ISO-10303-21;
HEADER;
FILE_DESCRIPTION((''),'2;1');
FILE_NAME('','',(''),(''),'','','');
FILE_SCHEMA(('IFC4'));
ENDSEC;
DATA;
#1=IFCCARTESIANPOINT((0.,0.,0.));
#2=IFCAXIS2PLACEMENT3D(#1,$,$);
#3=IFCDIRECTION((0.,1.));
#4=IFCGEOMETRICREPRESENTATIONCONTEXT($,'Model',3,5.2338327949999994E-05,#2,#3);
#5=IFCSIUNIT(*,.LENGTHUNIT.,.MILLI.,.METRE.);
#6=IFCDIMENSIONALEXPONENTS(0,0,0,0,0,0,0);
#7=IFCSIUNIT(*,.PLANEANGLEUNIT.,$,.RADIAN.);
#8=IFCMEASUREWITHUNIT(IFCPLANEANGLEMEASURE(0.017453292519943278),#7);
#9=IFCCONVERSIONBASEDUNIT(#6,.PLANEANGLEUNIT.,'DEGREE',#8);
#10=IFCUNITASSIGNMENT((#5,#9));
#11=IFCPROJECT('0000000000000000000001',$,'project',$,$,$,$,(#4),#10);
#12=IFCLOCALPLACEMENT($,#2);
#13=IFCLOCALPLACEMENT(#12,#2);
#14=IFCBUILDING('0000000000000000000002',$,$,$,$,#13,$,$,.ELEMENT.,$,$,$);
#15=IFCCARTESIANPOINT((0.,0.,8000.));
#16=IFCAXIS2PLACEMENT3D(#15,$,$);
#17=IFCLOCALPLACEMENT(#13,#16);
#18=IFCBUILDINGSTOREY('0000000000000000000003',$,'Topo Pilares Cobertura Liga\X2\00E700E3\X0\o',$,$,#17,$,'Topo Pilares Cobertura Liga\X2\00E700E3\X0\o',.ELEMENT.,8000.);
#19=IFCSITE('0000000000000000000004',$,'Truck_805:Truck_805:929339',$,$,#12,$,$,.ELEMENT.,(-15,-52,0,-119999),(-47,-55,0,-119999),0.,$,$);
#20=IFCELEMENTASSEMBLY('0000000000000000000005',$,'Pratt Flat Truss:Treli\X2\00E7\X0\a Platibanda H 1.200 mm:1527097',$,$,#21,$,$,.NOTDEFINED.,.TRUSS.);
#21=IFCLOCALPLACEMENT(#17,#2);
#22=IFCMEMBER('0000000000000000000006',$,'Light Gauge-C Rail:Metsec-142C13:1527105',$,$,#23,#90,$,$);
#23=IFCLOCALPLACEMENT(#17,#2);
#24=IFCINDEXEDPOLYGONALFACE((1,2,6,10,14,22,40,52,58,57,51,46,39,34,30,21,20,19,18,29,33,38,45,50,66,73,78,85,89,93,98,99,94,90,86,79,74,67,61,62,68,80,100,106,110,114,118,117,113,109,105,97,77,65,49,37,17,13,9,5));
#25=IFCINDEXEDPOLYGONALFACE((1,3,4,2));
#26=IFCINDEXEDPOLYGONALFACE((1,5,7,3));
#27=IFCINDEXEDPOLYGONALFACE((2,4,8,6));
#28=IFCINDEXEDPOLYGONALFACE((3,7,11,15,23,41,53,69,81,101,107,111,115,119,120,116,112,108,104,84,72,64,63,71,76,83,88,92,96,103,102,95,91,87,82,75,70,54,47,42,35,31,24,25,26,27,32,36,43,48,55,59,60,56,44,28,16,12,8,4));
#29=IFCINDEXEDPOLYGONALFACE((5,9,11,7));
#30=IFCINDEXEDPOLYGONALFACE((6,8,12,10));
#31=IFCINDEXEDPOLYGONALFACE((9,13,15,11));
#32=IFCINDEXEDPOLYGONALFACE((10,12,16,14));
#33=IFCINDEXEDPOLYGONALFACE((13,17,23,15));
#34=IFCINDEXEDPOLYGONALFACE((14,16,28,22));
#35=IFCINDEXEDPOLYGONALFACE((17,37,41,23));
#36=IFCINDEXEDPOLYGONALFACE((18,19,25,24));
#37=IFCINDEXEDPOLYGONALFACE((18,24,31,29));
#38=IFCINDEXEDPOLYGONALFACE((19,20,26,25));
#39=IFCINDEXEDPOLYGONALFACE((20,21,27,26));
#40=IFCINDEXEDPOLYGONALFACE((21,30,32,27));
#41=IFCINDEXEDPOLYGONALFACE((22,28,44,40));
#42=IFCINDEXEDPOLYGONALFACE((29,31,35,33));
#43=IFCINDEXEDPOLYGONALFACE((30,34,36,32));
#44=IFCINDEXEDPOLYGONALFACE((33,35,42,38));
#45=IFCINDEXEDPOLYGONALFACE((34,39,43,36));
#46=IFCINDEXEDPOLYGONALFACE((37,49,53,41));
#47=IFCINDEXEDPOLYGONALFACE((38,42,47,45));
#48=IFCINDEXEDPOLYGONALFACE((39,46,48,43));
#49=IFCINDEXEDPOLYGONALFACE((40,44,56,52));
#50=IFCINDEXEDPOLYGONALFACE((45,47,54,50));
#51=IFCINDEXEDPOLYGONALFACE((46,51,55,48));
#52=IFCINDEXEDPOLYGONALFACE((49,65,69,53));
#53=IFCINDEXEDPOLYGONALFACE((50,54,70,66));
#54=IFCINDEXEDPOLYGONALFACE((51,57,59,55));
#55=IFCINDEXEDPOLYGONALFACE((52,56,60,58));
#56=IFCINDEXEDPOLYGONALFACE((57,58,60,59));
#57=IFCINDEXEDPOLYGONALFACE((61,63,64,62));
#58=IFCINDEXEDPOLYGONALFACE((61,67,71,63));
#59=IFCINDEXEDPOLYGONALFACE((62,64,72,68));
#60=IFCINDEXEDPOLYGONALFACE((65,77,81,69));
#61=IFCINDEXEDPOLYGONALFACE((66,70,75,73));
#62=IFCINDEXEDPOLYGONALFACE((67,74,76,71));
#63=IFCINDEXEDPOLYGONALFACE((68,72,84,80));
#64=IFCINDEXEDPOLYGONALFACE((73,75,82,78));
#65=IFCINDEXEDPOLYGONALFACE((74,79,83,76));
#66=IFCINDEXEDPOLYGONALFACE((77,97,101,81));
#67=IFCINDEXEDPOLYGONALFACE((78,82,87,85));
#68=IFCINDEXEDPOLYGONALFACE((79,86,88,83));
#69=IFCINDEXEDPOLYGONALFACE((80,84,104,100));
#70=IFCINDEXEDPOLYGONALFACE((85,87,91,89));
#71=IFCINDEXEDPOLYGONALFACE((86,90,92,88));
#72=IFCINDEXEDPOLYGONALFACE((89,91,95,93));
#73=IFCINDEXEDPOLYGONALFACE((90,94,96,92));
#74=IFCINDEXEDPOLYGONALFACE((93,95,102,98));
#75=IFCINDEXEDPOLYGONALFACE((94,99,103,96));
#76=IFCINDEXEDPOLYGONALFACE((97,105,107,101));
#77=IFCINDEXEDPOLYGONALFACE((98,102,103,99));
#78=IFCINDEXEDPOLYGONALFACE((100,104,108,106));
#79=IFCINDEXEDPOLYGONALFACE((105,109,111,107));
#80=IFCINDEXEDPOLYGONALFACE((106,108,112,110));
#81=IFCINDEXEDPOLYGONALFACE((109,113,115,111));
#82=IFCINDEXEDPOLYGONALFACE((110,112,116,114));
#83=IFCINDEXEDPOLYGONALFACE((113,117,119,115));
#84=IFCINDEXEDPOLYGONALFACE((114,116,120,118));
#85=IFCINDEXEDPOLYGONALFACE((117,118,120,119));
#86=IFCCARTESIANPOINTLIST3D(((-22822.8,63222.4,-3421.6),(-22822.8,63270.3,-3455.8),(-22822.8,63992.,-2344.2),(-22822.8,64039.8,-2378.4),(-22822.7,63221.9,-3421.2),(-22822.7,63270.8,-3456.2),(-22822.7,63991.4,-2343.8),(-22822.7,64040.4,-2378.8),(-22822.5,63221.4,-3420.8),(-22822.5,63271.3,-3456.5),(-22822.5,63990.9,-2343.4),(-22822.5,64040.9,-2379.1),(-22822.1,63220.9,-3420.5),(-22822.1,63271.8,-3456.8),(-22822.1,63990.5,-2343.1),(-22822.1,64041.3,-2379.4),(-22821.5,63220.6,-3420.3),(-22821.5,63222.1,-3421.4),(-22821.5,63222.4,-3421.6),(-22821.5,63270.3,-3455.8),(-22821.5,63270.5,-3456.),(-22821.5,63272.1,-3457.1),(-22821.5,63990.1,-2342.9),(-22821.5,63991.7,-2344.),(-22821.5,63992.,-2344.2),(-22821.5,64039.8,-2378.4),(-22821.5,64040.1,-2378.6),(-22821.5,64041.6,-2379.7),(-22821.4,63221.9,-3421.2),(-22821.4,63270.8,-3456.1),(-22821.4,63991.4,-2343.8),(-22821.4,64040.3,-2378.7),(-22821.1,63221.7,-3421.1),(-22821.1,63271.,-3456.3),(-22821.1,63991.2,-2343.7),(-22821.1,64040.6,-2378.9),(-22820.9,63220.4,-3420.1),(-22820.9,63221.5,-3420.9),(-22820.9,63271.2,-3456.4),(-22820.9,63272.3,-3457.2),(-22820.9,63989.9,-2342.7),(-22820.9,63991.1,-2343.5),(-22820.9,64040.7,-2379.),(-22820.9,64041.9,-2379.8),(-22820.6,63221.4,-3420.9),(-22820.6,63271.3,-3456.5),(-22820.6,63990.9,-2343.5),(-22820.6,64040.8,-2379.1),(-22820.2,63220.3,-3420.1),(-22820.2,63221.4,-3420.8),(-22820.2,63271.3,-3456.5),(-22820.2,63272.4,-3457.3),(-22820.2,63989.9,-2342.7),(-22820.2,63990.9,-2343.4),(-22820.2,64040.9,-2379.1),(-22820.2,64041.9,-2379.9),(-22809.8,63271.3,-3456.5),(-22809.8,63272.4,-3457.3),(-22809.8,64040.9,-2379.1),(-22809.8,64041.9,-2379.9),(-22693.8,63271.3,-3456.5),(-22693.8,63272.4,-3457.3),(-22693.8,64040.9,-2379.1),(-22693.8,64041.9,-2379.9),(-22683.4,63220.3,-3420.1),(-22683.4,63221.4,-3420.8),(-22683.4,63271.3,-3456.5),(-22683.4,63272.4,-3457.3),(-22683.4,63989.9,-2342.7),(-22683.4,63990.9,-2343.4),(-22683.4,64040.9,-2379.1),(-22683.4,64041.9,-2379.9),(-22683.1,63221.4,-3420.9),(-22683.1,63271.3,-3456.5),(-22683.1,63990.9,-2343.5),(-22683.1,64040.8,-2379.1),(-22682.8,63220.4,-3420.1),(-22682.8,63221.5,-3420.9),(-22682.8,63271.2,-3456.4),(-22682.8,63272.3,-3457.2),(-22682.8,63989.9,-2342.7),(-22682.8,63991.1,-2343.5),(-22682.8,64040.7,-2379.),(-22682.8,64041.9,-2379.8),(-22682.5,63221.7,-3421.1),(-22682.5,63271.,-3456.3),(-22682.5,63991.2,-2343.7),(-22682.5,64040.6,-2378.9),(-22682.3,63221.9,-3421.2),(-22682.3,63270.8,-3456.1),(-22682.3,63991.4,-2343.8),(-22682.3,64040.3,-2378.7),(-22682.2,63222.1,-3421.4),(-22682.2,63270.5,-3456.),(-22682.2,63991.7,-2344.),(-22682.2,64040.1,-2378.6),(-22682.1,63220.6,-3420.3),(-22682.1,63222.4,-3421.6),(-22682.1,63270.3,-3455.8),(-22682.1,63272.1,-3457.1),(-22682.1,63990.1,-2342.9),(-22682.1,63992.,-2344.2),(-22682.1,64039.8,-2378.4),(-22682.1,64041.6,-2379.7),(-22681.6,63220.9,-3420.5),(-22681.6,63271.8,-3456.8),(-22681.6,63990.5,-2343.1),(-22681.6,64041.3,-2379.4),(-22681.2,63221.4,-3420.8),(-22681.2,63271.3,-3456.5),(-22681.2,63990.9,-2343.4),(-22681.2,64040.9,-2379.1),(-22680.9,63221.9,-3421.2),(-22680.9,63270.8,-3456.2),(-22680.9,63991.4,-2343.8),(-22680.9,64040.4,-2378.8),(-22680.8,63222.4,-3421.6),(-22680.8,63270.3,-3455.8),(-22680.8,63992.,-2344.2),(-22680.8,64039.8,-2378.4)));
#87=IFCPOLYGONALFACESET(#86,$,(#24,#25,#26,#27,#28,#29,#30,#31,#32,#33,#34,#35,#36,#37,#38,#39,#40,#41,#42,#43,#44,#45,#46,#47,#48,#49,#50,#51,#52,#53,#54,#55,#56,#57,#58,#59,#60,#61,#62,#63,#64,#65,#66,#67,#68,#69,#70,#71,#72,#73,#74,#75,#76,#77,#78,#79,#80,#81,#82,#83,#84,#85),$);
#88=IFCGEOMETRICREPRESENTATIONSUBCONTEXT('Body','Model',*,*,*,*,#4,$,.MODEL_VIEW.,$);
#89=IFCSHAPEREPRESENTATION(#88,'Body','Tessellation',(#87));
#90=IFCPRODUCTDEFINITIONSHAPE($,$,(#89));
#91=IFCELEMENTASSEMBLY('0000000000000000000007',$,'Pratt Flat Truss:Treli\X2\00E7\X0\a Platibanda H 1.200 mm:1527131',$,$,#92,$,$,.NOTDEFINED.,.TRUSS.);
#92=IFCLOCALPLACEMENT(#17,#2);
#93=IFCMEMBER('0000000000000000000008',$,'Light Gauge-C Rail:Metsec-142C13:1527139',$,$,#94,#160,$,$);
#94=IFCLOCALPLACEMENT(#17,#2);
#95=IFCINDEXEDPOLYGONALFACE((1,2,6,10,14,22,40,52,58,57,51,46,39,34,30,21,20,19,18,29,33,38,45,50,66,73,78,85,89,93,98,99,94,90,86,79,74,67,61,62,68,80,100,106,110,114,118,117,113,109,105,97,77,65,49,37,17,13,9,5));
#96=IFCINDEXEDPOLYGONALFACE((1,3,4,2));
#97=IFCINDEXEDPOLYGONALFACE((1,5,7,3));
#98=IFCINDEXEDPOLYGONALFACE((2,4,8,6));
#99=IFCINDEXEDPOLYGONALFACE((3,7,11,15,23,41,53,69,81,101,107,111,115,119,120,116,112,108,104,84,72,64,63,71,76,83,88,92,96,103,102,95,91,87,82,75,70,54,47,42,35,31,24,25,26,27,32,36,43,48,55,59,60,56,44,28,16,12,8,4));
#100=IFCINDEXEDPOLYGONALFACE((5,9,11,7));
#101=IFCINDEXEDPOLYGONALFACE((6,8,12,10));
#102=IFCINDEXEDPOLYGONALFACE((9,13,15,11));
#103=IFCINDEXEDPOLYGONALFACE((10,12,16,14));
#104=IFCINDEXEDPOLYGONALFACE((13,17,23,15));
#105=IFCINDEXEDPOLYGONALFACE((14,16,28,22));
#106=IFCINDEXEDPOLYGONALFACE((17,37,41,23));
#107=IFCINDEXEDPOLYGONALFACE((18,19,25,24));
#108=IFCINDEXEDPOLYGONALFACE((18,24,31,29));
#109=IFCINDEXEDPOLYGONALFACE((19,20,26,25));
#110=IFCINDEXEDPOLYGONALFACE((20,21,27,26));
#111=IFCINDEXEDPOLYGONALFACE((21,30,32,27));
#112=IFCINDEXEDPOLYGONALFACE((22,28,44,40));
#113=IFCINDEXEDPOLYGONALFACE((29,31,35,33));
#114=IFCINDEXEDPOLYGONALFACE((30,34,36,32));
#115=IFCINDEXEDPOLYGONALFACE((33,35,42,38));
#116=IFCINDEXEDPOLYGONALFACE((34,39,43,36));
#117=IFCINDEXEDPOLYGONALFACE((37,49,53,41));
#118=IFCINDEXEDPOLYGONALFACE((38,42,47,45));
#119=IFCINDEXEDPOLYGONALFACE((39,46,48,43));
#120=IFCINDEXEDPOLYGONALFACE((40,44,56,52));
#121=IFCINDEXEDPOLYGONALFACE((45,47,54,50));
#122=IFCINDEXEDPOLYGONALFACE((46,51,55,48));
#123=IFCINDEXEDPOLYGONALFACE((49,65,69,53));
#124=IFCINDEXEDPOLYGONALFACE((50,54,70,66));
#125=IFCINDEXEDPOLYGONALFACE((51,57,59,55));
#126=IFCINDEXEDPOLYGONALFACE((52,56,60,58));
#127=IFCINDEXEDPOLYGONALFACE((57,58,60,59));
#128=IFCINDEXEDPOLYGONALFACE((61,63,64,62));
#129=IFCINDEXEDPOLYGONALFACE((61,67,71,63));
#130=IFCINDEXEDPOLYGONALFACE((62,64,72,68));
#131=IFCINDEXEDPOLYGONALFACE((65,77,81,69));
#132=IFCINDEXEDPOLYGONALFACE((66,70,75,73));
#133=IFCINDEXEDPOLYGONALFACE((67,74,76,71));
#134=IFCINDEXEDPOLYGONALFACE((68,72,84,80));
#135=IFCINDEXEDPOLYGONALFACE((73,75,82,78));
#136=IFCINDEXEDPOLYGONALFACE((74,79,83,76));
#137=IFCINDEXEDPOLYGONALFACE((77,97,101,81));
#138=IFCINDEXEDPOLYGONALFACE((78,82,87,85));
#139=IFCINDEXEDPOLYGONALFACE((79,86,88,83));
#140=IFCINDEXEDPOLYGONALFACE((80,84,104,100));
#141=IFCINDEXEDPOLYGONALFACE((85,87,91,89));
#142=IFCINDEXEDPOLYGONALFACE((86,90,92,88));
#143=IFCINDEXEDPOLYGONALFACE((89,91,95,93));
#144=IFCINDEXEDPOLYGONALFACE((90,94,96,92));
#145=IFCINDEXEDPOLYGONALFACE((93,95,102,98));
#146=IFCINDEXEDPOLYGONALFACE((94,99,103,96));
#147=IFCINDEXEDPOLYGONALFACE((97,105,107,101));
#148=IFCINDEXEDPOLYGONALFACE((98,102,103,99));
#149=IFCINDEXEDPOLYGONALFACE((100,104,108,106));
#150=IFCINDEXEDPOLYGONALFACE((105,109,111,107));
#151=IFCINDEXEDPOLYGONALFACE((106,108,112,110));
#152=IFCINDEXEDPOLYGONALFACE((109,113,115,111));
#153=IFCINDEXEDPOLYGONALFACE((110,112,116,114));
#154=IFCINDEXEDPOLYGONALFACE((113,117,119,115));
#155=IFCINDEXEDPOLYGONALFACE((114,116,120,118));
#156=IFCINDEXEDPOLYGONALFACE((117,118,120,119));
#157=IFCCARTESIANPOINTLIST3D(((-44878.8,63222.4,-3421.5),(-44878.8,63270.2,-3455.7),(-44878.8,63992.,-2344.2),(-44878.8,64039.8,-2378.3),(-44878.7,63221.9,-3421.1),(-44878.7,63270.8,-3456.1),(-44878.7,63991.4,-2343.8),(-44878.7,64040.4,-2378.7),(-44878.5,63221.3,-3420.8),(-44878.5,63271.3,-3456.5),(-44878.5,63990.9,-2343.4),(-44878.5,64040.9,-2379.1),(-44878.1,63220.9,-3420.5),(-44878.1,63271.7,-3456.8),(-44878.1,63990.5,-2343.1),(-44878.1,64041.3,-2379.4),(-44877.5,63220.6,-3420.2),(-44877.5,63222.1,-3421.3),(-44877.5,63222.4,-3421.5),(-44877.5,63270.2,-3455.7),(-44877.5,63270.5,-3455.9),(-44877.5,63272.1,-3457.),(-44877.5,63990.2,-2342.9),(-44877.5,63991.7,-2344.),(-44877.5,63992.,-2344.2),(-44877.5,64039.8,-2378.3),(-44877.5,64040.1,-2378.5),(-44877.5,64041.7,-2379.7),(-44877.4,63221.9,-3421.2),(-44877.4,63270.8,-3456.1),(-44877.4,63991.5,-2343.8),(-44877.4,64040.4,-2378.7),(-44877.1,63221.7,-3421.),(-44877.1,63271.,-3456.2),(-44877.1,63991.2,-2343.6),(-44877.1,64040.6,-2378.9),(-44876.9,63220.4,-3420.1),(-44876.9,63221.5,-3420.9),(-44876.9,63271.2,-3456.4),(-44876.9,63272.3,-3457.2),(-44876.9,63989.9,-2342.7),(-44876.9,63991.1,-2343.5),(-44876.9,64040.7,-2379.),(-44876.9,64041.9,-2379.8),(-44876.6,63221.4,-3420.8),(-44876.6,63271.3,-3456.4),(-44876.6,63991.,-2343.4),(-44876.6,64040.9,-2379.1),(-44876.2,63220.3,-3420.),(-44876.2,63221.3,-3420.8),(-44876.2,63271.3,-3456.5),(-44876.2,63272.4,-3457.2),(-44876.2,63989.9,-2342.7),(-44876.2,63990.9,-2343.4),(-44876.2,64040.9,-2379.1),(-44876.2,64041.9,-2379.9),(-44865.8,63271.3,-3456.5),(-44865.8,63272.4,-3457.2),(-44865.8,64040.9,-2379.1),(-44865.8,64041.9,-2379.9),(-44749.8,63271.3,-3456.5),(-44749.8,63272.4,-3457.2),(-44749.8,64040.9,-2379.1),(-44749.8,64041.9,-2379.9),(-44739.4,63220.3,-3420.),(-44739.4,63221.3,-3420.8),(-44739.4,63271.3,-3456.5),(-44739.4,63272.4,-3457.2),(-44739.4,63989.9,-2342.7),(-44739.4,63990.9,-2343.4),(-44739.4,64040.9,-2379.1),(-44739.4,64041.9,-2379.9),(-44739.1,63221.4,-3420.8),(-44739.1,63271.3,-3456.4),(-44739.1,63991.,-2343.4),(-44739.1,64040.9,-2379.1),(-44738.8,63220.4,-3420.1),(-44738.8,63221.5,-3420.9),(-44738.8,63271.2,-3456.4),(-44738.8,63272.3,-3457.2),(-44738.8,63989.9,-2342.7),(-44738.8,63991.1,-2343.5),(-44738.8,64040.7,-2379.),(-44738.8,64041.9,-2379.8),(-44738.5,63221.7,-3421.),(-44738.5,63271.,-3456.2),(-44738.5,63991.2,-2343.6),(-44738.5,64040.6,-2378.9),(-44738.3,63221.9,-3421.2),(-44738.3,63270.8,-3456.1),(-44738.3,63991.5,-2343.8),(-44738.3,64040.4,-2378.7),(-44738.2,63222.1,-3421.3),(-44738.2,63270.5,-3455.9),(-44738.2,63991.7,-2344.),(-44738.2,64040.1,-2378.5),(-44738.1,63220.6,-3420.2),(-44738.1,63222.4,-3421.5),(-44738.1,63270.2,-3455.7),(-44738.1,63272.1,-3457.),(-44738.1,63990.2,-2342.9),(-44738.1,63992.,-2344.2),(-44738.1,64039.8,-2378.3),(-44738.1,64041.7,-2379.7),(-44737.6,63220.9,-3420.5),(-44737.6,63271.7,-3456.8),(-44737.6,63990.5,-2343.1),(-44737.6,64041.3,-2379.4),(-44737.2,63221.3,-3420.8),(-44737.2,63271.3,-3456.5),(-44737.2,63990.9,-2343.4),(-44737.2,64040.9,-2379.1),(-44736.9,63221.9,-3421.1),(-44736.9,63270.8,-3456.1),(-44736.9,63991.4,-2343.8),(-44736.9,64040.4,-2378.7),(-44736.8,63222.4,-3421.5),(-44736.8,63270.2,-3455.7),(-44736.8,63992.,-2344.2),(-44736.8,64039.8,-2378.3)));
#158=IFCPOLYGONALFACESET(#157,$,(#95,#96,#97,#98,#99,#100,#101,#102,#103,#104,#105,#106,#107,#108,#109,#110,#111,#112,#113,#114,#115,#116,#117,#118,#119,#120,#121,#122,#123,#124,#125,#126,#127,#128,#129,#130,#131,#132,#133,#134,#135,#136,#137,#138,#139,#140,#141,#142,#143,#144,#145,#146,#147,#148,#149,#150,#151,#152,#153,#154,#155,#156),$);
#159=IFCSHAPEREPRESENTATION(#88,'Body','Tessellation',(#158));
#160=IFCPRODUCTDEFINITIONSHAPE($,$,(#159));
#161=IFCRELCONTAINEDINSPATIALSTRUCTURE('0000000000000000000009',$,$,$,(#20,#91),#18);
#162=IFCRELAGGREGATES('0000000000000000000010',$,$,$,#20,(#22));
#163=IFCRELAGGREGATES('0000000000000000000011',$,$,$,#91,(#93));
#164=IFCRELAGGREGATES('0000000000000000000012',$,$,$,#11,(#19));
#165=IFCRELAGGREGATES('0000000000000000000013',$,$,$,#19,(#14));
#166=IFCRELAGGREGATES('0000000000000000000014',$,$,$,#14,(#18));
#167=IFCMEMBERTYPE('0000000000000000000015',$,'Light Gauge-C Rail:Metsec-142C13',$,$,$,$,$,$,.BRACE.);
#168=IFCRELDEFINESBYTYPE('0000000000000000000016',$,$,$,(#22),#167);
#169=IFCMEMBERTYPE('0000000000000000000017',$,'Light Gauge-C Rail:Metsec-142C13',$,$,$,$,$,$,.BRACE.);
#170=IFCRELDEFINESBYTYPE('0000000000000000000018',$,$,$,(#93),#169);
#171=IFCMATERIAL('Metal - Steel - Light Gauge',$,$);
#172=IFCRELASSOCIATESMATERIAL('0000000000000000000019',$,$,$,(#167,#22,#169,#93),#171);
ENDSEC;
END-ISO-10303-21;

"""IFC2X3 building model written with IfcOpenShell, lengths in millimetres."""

from ifc_helpers import new_model, entity, si_unit, converted_unit, direction, frame, frame_2d, origin, place, context, subcontext, project, spatial, polyline, circle_curve, parameter, trimmed, segment, composite_curve, outline, extrude, source, transform, mapped, material, type_object, type_shapes, element, aggregate, save


model = new_model("IFC2X3")

# Units and contexts
model_context = context("Model", 3, precision=5.2338327949999994e-05, world=origin(), true_north=direction((0.0, 1.0)))
body_context = subcontext(model_context, "Body", "Model", "MODEL_VIEW")
ifc_project = project(units=[si_unit("LENGTHUNIT", "METRE", prefix="MILLI"), converted_unit("PLANEANGLEUNIT", "DEGREE", entity("IfcPlaneAngleMeasure", 0.017453292519943278), si_unit("PLANEANGLEUNIT", "RADIAN"), dimensions=[0, 0, 0, 0, 0, 0, 0])], contexts=[model_context])

# Site, building, storey
site_placement = place(None, origin())
site = spatial("IfcSite", under=ifc_project, at=site_placement, Name="Truck_805:Truck_805:929339", CompositionType="ELEMENT", RefLatitude=(-15, -52, 0, -119999), RefLongitude=(-47, -55, 0, -119999), RefElevation=0.0)
building_placement = place(site_placement, origin())
building = spatial("IfcBuilding", under=site, at=building_placement, CompositionType="ELEMENT")
storey_placement = place(building_placement, frame((0.0, 0.0, 8000.0)))
storey = spatial("IfcBuildingStorey", under=building, at=storey_placement, Name="Topo Pilares Cobertura Ligação", LongName="Topo Pilares Cobertura Ligação", CompositionType="ELEMENT", Elevation=8000.0)

# Element assembly, member
assembly_1_placement = place(storey_placement, origin())
assembly_1 = element("IfcElementAssembly", 1, at=assembly_1_placement, inside=storey, Name="Pratt Flat Truss:Treliça Platibanda H 1.200 mm:1527097", AssemblyPlace="NOTDEFINED", PredefinedType="TRUSS")
ifc_material_1 = material(Name="Metal - Steel - Light Gauge")
member_type_1 = type_object("IfcMemberType", Name="Light Gauge-C Rail:Metsec-142C13", PredefinedType="BRACE", material=ifc_material_1)
shared_shape_1 = source(origin(), body_context, "Body", "SweptSolid", [
    extrude(outline(composite_curve([segment(polyline([(-23.1, -71.0), (35.7, -71.0)]), True, "CONTINUOUS"), segment(trimmed(circle_curve(frame_2d((35.7, -68.4), x_axis=(0.0, -1.0)), 2.6), [parameter(0.0)], [parameter(90.0)], True, "PARAMETER"), True, "CONTINUOUS"), segment(polyline([(38.3, -68.4), (38.3, 68.4)]), True, "CONTINUOUS"), segment(trimmed(circle_curve(frame_2d((35.7, 68.4), x_axis=(1.0, 0.0)), 2.6), [parameter(0.0)], [parameter(90.0)], True, "PARAMETER"), True, "CONTINUOUS"), segment(polyline([(35.7, 71.0), (-23.1, 71.0)]), True, "CONTINUOUS"), segment(trimmed(circle_curve(frame_2d((-23.1, 68.4), x_axis=(0.0, 1.0)), 2.6), [parameter(0.0)], [parameter(90.0)], True, "PARAMETER"), True, "CONTINUOUS"), segment(polyline([(-25.7, 68.4), (-25.7, 58.0)]), True, "CONTINUOUS"), segment(polyline([(-25.7, 58.0), (-24.4, 58.0)]), True, "CONTINUOUS"), segment(polyline([(-24.4, 58.0), (-24.4, 68.4)]), True, "CONTINUOUS"), segment(trimmed(circle_curve(frame_2d((-23.1, 68.4), x_axis=(-1.0, 0.0)), 1.3), [parameter(270.0)], [parameter(0.0)], True, "PARAMETER"), False, "CONTINUOUS"), segment(polyline([(-23.1, 69.7), (35.7, 69.7)]), True, "CONTINUOUS"), segment(trimmed(circle_curve(frame_2d((35.7, 68.4), x_axis=(0.0, 1.0)), 1.3), [parameter(270.0)], [parameter(0.0)], True, "PARAMETER"), False, "CONTINUOUS"), segment(polyline([(37.0, 68.4), (37.0, -68.4)]), True, "CONTINUOUS"), segment(trimmed(circle_curve(frame_2d((35.7, -68.4), x_axis=(1.0, 0.0)), 1.3), [parameter(270.0)], [parameter(0.0)], True, "PARAMETER"), False, "CONTINUOUS"), segment(polyline([(35.7, -69.7), (-23.1, -69.7)]), True, "CONTINUOUS"), segment(trimmed(circle_curve(frame_2d((-23.1, -68.4), x_axis=(0.0, -1.0)), 1.3), [parameter(270.0)], [parameter(0.0)], True, "PARAMETER"), False, "CONTINUOUS"), segment(polyline([(-24.4, -68.4), (-24.4, -58.0)]), True, "CONTINUOUS"), segment(polyline([(-24.4, -58.0), (-25.7, -58.0)]), True, "CONTINUOUS"), segment(polyline([(-25.7, -58.0), (-25.7, -68.4)]), True, "CONTINUOUS"), segment(trimmed(circle_curve(frame_2d((-23.1, -68.4), x_axis=(-1.0, 0.0)), 2.6), [parameter(0.0)], [parameter(90.0)], True, "PARAMETER"), True, "CONTINUOUS")], self_intersect=False)), frame((-22751.8, 63251.4, 4557.7), z_axis=(0.0, 0.581231, 0.813738), x_axis=(0.0, -0.813738, 0.581231)), (0.0, 0.0, 1.0), 1324.0),
])
type_shapes(member_type_1, [shared_shape_1])
member_1_placement = place(assembly_1_placement, frame((0.0, 0.0, -8000.0)))
member_1 = element("IfcMember", 2, at=member_1_placement, type_object=member_type_1, material=ifc_material_1, Name="Light Gauge-C Rail:Metsec-142C13:1527105", context=body_context, shape_type="MappedRepresentation", body=[
    mapped(shared_shape_1, transform((0.0, 0.0, 0.0), scale=1.0)),
])
aggregate(assembly_1, [member_1])

# Element assembly, member
assembly_2_placement = place(storey_placement, origin())
assembly_2 = element("IfcElementAssembly", 3, at=assembly_2_placement, inside=storey, Name="Pratt Flat Truss:Treliça Platibanda H 1.200 mm:1527131", AssemblyPlace="NOTDEFINED", PredefinedType="TRUSS")
member_type_2 = type_object("IfcMemberType", Name="Light Gauge-C Rail:Metsec-142C13", PredefinedType="BRACE", material=ifc_material_1)
shared_shape_2 = source(origin(), body_context, "Body", "SweptSolid", [
    extrude(outline(composite_curve([segment(polyline([(-23.1, -71.0), (35.7, -71.0)]), True, "CONTINUOUS"), segment(trimmed(circle_curve(frame_2d((35.7, -68.4), x_axis=(0.0, -1.0)), 2.6), [parameter(0.0)], [parameter(90.0)], True, "PARAMETER"), True, "CONTINUOUS"), segment(polyline([(38.3, -68.4), (38.3, 68.4)]), True, "CONTINUOUS"), segment(trimmed(circle_curve(frame_2d((35.7, 68.4), x_axis=(1.0, 0.0)), 2.6), [parameter(0.0)], [parameter(90.0)], True, "PARAMETER"), True, "CONTINUOUS"), segment(polyline([(35.7, 71.0), (-23.1, 71.0)]), True, "CONTINUOUS"), segment(trimmed(circle_curve(frame_2d((-23.1, 68.4), x_axis=(0.0, 1.0)), 2.6), [parameter(0.0)], [parameter(90.0)], True, "PARAMETER"), True, "CONTINUOUS"), segment(polyline([(-25.7, 68.4), (-25.7, 58.0)]), True, "CONTINUOUS"), segment(polyline([(-25.7, 58.0), (-24.4, 58.0)]), True, "CONTINUOUS"), segment(polyline([(-24.4, 58.0), (-24.4, 68.4)]), True, "CONTINUOUS"), segment(trimmed(circle_curve(frame_2d((-23.1, 68.4), x_axis=(-1.0, 0.0)), 1.3), [parameter(270.0)], [parameter(0.0)], True, "PARAMETER"), False, "CONTINUOUS"), segment(polyline([(-23.1, 69.7), (35.7, 69.7)]), True, "CONTINUOUS"), segment(trimmed(circle_curve(frame_2d((35.7, 68.4), x_axis=(0.0, 1.0)), 1.3), [parameter(270.0)], [parameter(0.0)], True, "PARAMETER"), False, "CONTINUOUS"), segment(polyline([(37.0, 68.4), (37.0, -68.4)]), True, "CONTINUOUS"), segment(trimmed(circle_curve(frame_2d((35.7, -68.4), x_axis=(1.0, 0.0)), 1.3), [parameter(270.0)], [parameter(0.0)], True, "PARAMETER"), False, "CONTINUOUS"), segment(polyline([(35.7, -69.7), (-23.1, -69.7)]), True, "CONTINUOUS"), segment(trimmed(circle_curve(frame_2d((-23.1, -68.4), x_axis=(0.0, -1.0)), 1.3), [parameter(270.0)], [parameter(0.0)], True, "PARAMETER"), False, "CONTINUOUS"), segment(polyline([(-24.4, -68.4), (-24.4, -58.0)]), True, "CONTINUOUS"), segment(polyline([(-24.4, -58.0), (-25.7, -58.0)]), True, "CONTINUOUS"), segment(polyline([(-25.7, -58.0), (-25.7, -68.4)]), True, "CONTINUOUS"), segment(trimmed(circle_curve(frame_2d((-23.1, -68.4), x_axis=(-1.0, 0.0)), 2.6), [parameter(0.0)], [parameter(90.0)], True, "PARAMETER"), True, "CONTINUOUS")], self_intersect=False)), frame((-44807.8, 63251.4, 4557.7), z_axis=(0.0, 0.581255, 0.813722), x_axis=(0.0, -0.813722, 0.581255)), (0.0, 0.0, 1.0), 1324.0),
])
type_shapes(member_type_2, [shared_shape_2])
member_2_placement = place(assembly_2_placement, frame((0.0, 0.0, -8000.0)))
member_2 = element("IfcMember", 4, at=member_2_placement, type_object=member_type_2, material=ifc_material_1, Name="Light Gauge-C Rail:Metsec-142C13:1527139", context=body_context, shape_type="MappedRepresentation", body=[
    mapped(shared_shape_2, transform((0.0, 0.0, 0.0), scale=1.0)),
])
aggregate(assembly_2, [member_2])

save(model, "model.ifc")
